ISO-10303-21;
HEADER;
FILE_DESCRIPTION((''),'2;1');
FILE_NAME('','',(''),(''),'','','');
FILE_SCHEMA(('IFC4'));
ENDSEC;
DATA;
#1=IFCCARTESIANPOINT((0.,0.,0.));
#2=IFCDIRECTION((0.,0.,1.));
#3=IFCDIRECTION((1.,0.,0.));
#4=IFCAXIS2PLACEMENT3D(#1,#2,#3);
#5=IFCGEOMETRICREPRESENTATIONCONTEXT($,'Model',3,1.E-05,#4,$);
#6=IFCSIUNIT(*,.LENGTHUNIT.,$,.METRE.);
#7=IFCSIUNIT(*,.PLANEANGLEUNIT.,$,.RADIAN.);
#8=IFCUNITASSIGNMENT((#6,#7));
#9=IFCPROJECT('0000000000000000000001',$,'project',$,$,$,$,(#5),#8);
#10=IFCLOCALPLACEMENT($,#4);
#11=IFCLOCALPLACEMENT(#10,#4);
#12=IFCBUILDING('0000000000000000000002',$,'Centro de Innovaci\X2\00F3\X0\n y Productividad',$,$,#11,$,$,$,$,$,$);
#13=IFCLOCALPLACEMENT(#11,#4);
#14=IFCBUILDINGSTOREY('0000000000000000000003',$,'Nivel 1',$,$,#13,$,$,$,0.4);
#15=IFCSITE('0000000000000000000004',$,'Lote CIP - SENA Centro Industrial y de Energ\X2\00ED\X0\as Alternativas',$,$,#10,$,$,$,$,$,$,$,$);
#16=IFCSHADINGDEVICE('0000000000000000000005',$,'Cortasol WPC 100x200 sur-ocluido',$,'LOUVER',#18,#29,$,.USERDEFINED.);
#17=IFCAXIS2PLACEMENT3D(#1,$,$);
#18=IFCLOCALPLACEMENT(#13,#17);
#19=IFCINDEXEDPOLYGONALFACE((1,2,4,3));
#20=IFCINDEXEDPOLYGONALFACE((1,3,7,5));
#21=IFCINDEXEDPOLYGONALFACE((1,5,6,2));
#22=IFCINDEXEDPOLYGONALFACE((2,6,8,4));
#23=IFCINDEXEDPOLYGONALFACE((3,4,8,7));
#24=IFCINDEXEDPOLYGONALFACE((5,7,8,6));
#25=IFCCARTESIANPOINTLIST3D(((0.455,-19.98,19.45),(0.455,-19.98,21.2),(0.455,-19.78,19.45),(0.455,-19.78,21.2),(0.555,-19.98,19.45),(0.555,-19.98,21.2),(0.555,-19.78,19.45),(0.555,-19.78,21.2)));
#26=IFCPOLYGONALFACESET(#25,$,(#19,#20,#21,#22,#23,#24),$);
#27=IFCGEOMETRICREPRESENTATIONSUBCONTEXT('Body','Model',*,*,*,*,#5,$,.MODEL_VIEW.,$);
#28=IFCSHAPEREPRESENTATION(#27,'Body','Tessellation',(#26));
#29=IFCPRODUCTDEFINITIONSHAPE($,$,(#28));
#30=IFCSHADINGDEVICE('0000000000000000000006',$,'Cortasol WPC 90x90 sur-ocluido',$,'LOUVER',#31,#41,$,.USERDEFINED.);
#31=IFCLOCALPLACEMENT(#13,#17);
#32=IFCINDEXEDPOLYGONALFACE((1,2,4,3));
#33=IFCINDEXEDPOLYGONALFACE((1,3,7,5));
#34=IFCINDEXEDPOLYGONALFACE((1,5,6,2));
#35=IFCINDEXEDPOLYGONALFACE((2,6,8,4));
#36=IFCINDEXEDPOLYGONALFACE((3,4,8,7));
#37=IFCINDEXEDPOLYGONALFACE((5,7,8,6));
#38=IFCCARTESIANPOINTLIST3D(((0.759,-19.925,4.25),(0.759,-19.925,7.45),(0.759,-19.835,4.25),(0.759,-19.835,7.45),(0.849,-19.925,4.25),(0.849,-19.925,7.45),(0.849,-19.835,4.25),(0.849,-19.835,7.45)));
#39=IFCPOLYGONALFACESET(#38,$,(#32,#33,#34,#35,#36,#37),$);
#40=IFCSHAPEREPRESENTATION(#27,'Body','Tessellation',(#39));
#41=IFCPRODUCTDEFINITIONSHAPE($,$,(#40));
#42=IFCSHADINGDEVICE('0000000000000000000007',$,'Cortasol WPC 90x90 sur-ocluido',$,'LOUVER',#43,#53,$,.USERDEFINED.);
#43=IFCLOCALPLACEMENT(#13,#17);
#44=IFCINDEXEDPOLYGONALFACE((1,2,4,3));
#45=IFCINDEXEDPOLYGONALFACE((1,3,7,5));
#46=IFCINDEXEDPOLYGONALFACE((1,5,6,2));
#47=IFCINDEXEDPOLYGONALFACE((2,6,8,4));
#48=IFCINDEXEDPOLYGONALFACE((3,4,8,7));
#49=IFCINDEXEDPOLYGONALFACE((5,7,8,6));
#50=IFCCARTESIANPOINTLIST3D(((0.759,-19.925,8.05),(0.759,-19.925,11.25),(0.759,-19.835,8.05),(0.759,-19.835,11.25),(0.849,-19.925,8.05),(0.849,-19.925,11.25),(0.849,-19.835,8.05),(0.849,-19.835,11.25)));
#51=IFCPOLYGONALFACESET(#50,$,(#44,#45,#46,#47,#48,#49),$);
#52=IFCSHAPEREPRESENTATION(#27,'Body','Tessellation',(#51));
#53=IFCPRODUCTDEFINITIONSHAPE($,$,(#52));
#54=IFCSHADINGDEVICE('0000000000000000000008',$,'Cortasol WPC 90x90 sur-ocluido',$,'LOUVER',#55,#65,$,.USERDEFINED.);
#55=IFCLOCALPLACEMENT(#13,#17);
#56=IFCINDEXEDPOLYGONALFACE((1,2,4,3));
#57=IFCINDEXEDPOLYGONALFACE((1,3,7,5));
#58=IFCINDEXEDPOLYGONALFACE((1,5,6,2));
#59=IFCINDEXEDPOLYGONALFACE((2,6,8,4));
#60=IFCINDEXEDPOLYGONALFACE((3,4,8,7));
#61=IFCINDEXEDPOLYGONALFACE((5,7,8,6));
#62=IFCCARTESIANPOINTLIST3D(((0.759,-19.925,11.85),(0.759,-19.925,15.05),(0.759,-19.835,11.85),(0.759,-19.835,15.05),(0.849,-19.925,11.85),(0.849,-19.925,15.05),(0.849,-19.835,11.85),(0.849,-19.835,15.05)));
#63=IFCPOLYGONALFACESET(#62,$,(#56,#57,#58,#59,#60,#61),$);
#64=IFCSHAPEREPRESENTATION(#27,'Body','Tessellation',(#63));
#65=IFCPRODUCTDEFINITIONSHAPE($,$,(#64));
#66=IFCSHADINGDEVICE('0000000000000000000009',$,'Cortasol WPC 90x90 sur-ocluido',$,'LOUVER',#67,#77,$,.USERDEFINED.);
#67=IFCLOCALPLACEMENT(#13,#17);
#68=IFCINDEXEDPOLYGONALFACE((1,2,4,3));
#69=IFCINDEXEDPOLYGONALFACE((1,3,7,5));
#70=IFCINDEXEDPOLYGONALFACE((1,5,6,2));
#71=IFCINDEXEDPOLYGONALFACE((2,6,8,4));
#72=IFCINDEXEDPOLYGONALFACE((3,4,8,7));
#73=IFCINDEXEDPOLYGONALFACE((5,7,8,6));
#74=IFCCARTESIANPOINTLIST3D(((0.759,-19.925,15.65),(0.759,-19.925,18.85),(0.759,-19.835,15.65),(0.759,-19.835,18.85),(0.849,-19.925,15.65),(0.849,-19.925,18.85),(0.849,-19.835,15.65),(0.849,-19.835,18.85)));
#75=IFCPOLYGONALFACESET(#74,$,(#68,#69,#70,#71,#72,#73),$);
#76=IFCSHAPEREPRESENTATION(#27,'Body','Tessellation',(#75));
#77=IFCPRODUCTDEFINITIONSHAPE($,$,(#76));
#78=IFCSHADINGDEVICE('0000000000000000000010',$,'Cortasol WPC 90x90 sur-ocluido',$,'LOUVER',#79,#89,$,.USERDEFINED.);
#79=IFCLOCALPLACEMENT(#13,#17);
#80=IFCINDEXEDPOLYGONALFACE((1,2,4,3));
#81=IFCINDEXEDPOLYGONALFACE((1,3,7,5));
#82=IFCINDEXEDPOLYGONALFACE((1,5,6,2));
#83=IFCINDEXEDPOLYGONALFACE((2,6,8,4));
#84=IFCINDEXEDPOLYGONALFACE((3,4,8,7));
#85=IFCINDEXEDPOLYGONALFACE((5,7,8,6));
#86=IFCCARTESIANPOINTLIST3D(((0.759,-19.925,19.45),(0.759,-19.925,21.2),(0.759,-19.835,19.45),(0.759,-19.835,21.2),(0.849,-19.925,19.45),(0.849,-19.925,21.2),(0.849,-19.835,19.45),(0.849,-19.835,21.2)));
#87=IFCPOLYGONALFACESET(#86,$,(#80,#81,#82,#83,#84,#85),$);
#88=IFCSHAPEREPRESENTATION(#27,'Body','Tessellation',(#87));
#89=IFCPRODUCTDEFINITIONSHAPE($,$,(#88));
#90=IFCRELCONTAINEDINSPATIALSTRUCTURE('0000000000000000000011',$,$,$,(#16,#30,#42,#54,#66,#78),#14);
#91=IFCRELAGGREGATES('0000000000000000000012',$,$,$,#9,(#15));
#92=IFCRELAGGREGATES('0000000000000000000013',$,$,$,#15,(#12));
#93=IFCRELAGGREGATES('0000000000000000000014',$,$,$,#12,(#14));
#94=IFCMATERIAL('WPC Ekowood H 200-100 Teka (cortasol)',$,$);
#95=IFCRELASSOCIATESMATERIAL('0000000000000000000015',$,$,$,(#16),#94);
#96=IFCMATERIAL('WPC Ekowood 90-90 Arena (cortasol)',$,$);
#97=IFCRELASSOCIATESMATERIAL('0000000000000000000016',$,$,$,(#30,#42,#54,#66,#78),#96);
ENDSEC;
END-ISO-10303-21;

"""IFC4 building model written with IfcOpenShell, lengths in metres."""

from ifc_helpers import new_model, si_unit, frame, origin_with_axes, place, context, subcontext, project, spatial, polyline, outline, extrude, material, element, save


model = new_model("IFC4")

# Units and contexts
model_context = context("Model", 3, precision=1e-05, world=origin_with_axes())
body_context = subcontext(model_context, "Body", "Model", "MODEL_VIEW")
ifc_project = project(units=[si_unit("LENGTHUNIT", "METRE"), si_unit("PLANEANGLEUNIT", "RADIAN")], contexts=[model_context])

# Site, building, storey
site_placement = place(None, origin_with_axes())
site = spatial("IfcSite", under=ifc_project, at=site_placement, Name="Lote CIP - SENA Centro Industrial y de Energías Alternativas")
building_placement = place(site_placement, origin_with_axes())
building = spatial("IfcBuilding", under=site, at=building_placement, Name="Centro de Innovación y Productividad")
storey_placement = place(building_placement, origin_with_axes())
storey = spatial("IfcBuildingStorey", under=building, at=storey_placement, Name="Nivel 1", Elevation=0.4)

# Shading devices
ifc_material_1 = material(Name="WPC Ekowood H 200-100 Teka (cortasol)")
ifc_material_2 = material(Name="WPC Ekowood 90-90 Arena (cortasol)")
shading_device_1_placement = place(storey_placement, origin_with_axes())
element("IfcShadingDevice", 1, at=shading_device_1_placement, inside=storey, material=ifc_material_1, Name="Cortasol WPC 100x200 sur-ocluido", ObjectType="LOUVER", PredefinedType="USERDEFINED", context=body_context, shape_type="SweptSolid", body=[
    extrude(outline(polyline([(0.455, -19.98), (0.455, -19.78), (0.555, -19.78), (0.555, -19.98), (0.455, -19.98)])), frame((0.0, 0.0, 19.45)), (0.0, 0.0, 1.0), 1.75),
])
shading_device_2_placement = place(storey_placement, origin_with_axes())
element("IfcShadingDevice", 2, at=shading_device_2_placement, inside=storey, material=ifc_material_2, Name="Cortasol WPC 90x90 sur-ocluido", ObjectType="LOUVER", PredefinedType="USERDEFINED", context=body_context, shape_type="SweptSolid", body=[
    extrude(outline(polyline([(0.759, -19.925), (0.759, -19.835), (0.849, -19.835), (0.849, -19.925), (0.759, -19.925)])), frame((0.0, 0.0, 4.25)), (0.0, 0.0, 1.0), 3.2),
])
shading_device_3_placement = place(storey_placement, origin_with_axes())
element("IfcShadingDevice", 3, at=shading_device_3_placement, inside=storey, material=ifc_material_2, Name="Cortasol WPC 90x90 sur-ocluido", ObjectType="LOUVER", PredefinedType="USERDEFINED", context=body_context, shape_type="SweptSolid", body=[
    extrude(outline(polyline([(0.759, -19.925), (0.759, -19.835), (0.849, -19.835), (0.849, -19.925), (0.759, -19.925)])), frame((0.0, 0.0, 8.05)), (0.0, 0.0, 1.0), 3.2),
])
shading_device_4_placement = place(storey_placement, origin_with_axes())
element("IfcShadingDevice", 4, at=shading_device_4_placement, inside=storey, material=ifc_material_2, Name="Cortasol WPC 90x90 sur-ocluido", ObjectType="LOUVER", PredefinedType="USERDEFINED", context=body_context, shape_type="SweptSolid", body=[
    extrude(outline(polyline([(0.759, -19.925), (0.759, -19.835), (0.849, -19.835), (0.849, -19.925), (0.759, -19.925)])), frame((0.0, 0.0, 11.85)), (0.0, 0.0, 1.0), 3.2),
])
shading_device_5_placement = place(storey_placement, origin_with_axes())
element("IfcShadingDevice", 5, at=shading_device_5_placement, inside=storey, material=ifc_material_2, Name="Cortasol WPC 90x90 sur-ocluido", ObjectType="LOUVER", PredefinedType="USERDEFINED", context=body_context, shape_type="SweptSolid", body=[
    extrude(outline(polyline([(0.759, -19.925), (0.759, -19.835), (0.849, -19.835), (0.849, -19.925), (0.759, -19.925)])), frame((0.0, 0.0, 15.65)), (0.0, 0.0, 1.0), 3.2),
])
shading_device_6_placement = place(storey_placement, origin_with_axes())
element("IfcShadingDevice", 6, at=shading_device_6_placement, inside=storey, material=ifc_material_2, Name="Cortasol WPC 90x90 sur-ocluido", ObjectType="LOUVER", PredefinedType="USERDEFINED", context=body_context, shape_type="SweptSolid", body=[
    extrude(outline(polyline([(0.759, -19.925), (0.759, -19.835), (0.849, -19.835), (0.849, -19.925), (0.759, -19.925)])), frame((0.0, 0.0, 19.45)), (0.0, 0.0, 1.0), 1.75),
])

save(model, "model.ifc")
